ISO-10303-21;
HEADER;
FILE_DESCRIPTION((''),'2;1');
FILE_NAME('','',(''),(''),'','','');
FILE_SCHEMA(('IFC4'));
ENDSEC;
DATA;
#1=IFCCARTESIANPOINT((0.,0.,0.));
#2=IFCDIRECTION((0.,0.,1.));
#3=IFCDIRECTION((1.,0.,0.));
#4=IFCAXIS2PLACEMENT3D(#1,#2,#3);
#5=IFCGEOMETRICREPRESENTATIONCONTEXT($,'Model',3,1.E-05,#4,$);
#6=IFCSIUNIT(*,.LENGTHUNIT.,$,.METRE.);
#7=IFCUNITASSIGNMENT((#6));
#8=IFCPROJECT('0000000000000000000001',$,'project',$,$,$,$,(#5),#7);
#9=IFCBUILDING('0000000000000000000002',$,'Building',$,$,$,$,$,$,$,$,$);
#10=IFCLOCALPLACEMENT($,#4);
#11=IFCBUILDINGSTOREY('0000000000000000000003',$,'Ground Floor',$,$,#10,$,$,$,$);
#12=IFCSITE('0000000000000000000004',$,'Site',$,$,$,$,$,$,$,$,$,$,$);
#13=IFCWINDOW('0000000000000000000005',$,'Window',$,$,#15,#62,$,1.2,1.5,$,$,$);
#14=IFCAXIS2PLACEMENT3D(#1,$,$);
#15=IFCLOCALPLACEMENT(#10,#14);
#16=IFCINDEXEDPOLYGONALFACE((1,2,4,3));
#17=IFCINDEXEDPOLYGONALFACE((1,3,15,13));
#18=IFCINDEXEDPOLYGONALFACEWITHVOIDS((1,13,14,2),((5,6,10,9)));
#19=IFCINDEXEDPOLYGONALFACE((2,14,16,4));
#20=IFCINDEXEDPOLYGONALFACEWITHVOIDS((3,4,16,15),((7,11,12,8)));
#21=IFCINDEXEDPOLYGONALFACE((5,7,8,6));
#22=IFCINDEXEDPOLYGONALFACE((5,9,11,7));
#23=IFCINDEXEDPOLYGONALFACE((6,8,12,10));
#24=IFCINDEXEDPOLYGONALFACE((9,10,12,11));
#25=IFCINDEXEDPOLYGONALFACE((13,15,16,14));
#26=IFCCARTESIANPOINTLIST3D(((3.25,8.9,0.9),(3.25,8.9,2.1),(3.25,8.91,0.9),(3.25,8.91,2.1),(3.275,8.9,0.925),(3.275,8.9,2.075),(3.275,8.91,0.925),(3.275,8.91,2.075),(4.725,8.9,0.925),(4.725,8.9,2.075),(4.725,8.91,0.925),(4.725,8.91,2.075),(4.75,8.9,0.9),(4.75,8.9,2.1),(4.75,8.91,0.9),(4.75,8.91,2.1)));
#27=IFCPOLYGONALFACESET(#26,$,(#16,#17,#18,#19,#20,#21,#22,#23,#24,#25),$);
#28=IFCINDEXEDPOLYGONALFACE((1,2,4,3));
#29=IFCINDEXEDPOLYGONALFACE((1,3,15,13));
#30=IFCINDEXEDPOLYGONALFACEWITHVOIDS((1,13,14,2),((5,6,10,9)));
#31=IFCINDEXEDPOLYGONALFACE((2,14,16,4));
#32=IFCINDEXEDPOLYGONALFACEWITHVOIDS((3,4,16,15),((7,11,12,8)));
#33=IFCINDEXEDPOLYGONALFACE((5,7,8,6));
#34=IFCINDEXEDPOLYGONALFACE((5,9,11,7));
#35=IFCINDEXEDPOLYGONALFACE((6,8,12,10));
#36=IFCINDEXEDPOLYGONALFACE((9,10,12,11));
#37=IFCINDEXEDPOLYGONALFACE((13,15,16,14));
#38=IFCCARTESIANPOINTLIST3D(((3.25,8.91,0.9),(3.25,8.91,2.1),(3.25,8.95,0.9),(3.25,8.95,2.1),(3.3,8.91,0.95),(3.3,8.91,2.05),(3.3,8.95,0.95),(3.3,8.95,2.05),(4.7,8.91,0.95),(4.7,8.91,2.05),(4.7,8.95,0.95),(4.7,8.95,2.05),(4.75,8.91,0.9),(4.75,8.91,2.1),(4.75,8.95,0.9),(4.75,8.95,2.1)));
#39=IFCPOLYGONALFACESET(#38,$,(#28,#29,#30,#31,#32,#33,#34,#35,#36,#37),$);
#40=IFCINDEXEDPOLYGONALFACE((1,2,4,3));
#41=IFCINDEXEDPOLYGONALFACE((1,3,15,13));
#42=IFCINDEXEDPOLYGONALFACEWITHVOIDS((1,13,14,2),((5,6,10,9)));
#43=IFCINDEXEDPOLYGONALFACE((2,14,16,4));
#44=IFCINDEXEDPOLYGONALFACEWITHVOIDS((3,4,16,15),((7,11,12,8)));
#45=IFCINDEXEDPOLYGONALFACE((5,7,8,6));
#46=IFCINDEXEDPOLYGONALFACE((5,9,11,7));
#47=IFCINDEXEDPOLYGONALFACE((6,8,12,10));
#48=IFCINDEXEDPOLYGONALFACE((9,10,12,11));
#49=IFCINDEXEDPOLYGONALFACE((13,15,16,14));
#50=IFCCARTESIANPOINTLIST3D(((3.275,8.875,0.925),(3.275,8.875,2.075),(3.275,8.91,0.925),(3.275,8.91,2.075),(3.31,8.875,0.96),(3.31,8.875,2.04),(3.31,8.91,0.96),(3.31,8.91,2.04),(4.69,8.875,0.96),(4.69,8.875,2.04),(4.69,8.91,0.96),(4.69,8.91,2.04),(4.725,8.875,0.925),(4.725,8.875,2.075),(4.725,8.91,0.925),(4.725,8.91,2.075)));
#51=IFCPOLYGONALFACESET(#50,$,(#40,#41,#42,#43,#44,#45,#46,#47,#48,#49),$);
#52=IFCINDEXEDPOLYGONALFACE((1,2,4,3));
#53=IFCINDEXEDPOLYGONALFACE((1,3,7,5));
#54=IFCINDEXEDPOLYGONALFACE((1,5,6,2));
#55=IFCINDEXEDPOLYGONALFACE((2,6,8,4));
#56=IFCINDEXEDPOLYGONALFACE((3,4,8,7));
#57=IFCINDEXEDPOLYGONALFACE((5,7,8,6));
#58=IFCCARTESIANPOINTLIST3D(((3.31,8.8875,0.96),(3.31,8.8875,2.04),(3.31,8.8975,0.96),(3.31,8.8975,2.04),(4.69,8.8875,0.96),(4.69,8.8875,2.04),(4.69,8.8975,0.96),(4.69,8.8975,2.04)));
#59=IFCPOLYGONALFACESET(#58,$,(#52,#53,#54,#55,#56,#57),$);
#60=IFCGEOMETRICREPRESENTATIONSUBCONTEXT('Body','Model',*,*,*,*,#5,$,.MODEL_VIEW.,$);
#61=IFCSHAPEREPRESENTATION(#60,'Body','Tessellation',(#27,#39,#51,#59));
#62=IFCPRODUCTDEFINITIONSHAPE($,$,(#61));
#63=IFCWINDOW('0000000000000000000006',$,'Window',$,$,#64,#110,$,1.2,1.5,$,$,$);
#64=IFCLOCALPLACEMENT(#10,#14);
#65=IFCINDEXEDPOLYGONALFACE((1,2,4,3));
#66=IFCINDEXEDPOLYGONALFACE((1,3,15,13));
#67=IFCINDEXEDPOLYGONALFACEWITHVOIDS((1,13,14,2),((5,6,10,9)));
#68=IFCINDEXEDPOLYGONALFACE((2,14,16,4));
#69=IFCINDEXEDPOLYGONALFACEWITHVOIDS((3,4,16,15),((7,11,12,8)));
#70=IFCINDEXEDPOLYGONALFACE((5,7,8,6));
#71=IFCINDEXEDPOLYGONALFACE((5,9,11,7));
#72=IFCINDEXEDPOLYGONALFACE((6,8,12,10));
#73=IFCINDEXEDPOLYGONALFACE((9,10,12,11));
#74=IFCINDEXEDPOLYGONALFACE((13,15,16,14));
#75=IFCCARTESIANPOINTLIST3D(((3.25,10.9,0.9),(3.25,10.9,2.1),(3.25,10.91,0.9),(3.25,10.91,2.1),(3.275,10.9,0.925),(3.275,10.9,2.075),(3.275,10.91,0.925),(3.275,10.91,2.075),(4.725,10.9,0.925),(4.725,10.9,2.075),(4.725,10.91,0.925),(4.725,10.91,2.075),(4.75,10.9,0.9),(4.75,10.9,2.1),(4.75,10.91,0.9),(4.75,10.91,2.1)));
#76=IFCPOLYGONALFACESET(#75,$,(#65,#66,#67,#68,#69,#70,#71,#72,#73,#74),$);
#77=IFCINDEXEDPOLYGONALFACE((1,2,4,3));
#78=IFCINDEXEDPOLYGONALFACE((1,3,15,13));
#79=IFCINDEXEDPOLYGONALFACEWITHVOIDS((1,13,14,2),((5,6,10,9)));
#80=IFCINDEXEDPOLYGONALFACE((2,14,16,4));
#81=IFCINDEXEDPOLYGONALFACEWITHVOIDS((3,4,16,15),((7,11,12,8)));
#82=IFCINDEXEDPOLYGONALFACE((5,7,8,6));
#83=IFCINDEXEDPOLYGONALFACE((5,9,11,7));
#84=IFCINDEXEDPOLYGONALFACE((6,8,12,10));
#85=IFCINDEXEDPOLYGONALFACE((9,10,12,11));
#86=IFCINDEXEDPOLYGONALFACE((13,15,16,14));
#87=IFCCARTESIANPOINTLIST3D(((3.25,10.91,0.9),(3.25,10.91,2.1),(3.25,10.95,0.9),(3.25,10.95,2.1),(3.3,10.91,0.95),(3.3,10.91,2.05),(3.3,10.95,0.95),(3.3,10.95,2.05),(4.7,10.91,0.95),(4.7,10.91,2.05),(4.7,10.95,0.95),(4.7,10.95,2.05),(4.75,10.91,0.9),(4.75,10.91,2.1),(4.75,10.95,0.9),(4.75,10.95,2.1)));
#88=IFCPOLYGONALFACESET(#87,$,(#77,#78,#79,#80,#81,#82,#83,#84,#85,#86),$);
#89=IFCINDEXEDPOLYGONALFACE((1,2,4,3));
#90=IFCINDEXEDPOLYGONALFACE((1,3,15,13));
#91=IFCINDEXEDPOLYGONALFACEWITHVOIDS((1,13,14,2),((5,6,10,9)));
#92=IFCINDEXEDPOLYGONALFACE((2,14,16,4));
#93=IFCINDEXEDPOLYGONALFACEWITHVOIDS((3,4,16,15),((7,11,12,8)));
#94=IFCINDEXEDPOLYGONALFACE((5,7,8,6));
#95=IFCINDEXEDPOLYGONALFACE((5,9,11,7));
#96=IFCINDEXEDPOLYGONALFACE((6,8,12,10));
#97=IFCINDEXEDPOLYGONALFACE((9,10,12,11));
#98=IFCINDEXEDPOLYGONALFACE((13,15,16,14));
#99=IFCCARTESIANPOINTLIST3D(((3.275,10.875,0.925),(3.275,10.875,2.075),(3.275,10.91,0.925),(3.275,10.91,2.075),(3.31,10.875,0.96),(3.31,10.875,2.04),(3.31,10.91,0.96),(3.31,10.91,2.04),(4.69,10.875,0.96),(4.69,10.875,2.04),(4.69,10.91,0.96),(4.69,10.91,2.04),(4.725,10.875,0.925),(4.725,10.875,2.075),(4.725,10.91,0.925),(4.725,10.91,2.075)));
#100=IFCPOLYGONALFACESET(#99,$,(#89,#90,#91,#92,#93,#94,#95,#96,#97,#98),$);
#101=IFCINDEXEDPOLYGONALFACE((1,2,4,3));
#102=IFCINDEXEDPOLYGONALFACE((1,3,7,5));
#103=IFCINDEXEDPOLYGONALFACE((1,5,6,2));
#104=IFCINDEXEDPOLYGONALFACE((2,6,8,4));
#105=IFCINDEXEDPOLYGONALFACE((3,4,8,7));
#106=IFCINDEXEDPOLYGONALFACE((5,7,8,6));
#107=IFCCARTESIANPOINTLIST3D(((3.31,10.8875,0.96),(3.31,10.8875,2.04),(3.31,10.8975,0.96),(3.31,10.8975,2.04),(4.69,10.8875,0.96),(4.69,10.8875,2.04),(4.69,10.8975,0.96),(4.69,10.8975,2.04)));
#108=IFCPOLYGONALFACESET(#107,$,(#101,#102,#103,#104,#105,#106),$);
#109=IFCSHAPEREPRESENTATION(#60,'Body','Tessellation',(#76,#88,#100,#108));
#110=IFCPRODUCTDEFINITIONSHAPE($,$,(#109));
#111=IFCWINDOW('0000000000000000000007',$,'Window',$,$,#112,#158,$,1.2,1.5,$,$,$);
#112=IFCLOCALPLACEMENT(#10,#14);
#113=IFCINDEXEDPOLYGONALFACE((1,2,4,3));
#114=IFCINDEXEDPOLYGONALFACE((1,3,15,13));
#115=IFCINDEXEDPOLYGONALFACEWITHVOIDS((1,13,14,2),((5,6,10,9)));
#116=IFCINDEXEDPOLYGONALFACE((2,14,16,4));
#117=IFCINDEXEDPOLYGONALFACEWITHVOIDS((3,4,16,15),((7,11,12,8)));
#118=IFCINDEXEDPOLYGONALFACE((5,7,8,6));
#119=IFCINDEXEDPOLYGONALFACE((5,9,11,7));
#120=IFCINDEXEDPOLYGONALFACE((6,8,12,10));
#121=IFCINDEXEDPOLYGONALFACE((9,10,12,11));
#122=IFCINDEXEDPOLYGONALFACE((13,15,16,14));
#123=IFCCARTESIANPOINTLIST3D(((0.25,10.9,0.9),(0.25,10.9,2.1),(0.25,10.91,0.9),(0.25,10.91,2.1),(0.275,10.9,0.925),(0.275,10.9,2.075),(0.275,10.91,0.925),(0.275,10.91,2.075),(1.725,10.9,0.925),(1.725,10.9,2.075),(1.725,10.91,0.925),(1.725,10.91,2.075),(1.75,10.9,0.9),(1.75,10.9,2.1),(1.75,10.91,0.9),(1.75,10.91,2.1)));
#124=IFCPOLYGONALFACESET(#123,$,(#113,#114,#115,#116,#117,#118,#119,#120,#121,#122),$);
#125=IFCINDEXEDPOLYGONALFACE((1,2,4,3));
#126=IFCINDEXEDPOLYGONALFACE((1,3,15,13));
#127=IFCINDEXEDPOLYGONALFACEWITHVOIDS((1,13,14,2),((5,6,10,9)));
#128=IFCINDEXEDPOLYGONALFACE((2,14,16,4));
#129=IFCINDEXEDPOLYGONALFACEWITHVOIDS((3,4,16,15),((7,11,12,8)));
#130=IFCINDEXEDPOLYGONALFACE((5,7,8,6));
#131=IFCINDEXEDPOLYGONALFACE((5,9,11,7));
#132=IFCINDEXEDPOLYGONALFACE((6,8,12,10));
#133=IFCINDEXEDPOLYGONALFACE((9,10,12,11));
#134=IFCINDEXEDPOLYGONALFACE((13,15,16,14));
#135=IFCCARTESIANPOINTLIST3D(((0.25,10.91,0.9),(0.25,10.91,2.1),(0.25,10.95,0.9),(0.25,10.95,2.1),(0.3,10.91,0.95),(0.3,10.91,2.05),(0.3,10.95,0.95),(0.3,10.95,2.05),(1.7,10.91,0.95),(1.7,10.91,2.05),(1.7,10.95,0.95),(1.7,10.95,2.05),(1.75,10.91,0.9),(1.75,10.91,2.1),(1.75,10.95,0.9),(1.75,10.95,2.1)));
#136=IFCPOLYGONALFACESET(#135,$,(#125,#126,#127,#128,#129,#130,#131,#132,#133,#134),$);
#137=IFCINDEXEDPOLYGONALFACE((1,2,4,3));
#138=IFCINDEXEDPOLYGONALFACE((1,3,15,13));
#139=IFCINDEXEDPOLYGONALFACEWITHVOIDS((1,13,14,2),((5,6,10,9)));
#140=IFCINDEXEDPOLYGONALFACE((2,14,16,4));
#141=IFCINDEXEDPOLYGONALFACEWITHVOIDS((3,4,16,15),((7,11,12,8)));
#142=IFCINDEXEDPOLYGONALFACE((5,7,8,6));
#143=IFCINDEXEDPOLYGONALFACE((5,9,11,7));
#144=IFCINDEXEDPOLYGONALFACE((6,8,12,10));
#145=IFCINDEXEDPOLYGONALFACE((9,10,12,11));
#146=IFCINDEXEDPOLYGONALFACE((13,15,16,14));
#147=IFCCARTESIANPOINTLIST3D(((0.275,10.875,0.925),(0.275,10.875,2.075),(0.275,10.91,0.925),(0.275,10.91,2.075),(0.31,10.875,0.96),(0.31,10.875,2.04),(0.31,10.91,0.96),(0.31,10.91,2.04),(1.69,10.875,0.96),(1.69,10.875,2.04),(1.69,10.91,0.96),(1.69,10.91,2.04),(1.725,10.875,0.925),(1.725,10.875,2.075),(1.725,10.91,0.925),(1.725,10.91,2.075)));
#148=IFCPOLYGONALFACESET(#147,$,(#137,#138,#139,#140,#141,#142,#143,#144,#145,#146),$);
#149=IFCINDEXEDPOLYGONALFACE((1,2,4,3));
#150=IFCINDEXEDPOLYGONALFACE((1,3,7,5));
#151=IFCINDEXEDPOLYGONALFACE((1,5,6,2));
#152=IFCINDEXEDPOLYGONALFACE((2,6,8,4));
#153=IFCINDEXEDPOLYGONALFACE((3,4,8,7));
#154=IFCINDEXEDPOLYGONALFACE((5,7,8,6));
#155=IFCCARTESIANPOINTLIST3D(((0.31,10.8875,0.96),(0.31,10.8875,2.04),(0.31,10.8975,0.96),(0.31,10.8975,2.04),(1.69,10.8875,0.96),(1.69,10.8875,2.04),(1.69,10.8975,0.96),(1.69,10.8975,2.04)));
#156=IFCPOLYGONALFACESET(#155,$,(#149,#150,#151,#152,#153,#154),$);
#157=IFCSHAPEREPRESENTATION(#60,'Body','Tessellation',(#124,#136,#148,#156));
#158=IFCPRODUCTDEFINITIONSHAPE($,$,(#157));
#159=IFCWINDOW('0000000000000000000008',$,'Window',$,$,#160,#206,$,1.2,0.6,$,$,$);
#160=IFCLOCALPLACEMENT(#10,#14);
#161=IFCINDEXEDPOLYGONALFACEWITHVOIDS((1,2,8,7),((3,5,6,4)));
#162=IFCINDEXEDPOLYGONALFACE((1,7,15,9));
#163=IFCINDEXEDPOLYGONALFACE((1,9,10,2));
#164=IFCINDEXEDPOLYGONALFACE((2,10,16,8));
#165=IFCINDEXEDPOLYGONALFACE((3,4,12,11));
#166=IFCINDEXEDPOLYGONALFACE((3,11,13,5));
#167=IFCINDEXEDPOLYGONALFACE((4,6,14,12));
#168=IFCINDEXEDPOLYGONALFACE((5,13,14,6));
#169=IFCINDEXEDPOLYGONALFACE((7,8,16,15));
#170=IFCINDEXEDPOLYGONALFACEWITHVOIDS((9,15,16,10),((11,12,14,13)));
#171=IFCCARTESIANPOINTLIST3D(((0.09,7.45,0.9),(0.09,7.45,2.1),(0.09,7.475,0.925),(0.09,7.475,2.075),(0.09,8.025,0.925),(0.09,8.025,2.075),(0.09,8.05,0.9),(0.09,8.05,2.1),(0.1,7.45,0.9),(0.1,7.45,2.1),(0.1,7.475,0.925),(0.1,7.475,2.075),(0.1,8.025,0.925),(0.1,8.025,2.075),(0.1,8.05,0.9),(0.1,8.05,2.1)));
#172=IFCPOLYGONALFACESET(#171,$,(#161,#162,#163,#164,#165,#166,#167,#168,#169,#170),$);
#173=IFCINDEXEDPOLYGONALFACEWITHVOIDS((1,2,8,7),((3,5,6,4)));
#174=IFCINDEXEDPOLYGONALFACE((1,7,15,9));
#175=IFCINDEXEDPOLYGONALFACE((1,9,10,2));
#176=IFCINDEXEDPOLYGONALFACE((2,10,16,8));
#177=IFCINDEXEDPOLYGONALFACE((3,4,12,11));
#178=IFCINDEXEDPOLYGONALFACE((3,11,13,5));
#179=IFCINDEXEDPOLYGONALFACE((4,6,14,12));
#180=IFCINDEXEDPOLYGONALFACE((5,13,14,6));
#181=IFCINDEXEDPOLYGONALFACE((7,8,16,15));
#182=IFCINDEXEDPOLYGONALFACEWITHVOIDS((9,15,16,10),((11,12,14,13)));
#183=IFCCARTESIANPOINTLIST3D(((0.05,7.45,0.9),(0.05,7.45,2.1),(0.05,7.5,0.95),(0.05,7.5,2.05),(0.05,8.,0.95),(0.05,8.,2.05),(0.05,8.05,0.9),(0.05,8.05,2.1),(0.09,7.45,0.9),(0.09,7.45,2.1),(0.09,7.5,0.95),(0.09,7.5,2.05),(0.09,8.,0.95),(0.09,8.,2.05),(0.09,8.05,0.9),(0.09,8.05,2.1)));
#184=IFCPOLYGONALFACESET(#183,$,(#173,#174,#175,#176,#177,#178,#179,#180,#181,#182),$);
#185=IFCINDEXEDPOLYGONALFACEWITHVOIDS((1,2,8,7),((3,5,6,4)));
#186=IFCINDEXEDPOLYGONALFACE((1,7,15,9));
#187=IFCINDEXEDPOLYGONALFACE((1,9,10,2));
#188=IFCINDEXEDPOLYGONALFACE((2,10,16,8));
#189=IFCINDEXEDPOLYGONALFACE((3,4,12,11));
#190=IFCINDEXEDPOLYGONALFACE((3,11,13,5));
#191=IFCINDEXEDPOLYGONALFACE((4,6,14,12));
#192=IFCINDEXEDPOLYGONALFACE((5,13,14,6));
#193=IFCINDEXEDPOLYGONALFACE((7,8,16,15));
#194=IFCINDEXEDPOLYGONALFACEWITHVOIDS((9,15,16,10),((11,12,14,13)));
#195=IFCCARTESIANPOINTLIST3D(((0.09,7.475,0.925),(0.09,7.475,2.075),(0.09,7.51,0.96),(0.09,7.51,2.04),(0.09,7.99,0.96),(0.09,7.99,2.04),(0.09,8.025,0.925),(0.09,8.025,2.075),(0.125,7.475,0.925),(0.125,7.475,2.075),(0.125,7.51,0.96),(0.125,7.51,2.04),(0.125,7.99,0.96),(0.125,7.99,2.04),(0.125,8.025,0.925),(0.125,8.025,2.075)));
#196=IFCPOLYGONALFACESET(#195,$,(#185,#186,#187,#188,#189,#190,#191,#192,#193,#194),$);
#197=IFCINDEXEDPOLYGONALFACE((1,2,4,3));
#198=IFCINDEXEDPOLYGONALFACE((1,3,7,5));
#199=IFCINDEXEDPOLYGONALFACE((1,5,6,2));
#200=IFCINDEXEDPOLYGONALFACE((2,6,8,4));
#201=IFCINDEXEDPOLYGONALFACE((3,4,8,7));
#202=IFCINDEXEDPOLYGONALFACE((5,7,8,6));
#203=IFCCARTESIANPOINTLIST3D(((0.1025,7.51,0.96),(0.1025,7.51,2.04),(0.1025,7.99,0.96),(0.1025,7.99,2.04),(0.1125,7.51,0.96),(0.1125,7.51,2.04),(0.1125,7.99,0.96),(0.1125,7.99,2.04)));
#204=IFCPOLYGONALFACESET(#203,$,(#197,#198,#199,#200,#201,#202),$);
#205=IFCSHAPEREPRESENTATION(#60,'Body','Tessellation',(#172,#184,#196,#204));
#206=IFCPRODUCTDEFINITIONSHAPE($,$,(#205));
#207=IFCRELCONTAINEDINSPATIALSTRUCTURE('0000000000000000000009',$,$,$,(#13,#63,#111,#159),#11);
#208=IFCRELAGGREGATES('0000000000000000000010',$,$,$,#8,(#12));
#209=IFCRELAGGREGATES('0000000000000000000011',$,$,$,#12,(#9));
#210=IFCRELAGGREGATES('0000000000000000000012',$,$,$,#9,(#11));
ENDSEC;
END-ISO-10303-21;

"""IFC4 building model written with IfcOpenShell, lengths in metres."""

from ifc_helpers import new_model, si_unit, frame, origin_with_axes, place, context, subcontext, project, spatial, line, indexed_curve, outline, extrude, element, save


model = new_model("IFC4")

# Units and contexts
model_context = context("Model", 3, precision=1e-05, world=origin_with_axes())
body_context = subcontext(model_context, "Body", "Model", "MODEL_VIEW")
ifc_project = project(units=[si_unit("LENGTHUNIT", "METRE")], contexts=[model_context])

# Site, building, storey
site = spatial("IfcSite", under=ifc_project, Name="Site")
building = spatial("IfcBuilding", under=site, Name="Building")
storey_placement = place(None, origin_with_axes())
storey = spatial("IfcBuildingStorey", under=building, at=storey_placement, Name="Ground Floor")

# Windows
for number, where, z_axis, x_axis, name in (
    (1, (4.75, 9.0, 0.9), (0.0, 0.0, 1.0), (-1.0, 0.0, 0.0), "Window"),
    (2, (4.75, 11.0, 0.9), (0.0, 0.0, 1.0), (-1.0, 0.0, 0.0), "Window"),
    (3, (1.75, 11.0, 0.9), (0.0, 0.0, 1.0), (-1.0, 0.0, 0.0), "Window"),
):
    element("IfcWindow", number, at=place(storey_placement, frame(where, z_axis=z_axis, x_axis=x_axis)), inside=storey, Name=name, OverallHeight=1.2, OverallWidth=1.5, context=body_context, shape_type="SweptSolid", body=[
        extrude(outline(indexed_curve([(0.0, 0.0), (1.5, 0.0), (1.5, 1.2), (0.0, 1.2)], segments=[line(1, 2, 3, 4, 1)]), holes=[indexed_curve([(0.025, 0.025), (1.475, 0.025), (1.475, 1.175), (0.025, 1.175)], segments=[line(1, 2, 3, 4, 1)])]), frame((0.0, 0.09, 0.0), z_axis=(0.0, -1.0, 0.0), x_axis=(1.0, 0.0, 0.0)), (0.0, 0.0, -1.0), 0.01),
        extrude(outline(indexed_curve([(0.0, 0.0), (1.5, 0.0), (1.5, 1.2), (0.0, 1.2)], segments=[line(1, 2, 3, 4, 1)]), holes=[indexed_curve([(0.05, 0.05), (1.45, 0.05), (1.45, 1.15), (0.05, 1.15)], segments=[line(1, 2, 3, 4, 1)])]), frame((0.0, 0.05, 0.0), z_axis=(0.0, -1.0, 0.0), x_axis=(1.0, 0.0, 0.0)), (0.0, 0.0, -1.0), 0.04),
        extrude(outline(indexed_curve([(0.0, 0.0), (1.45, 0.0), (1.45, 1.15), (0.0, 1.15)], segments=[line(1, 2, 3, 4, 1)]), holes=[indexed_curve([(0.035, 0.035), (1.415, 0.035), (1.415, 1.115), (0.035, 1.115)], segments=[line(1, 2, 3, 4, 1)])]), frame((0.025, 0.09, 0.025), z_axis=(0.0, -1.0, 0.0), x_axis=(1.0, 0.0, 0.0)), (0.0, 0.0, -1.0), 0.035),
        extrude(outline(indexed_curve([(0.035, 0.035), (1.415, 0.035), (1.415, 1.115), (0.035, 1.115)], segments=[line(1, 2, 3, 4, 1)])), frame((0.025, 0.1025, 0.025), z_axis=(0.0, -1.0, 0.0), x_axis=(1.0, 0.0, 0.0)), (0.0, 0.0, -1.0), 0.01),
    ])
window_placement = place(storey_placement, frame((0.0, 8.05, 0.9), z_axis=(0.0, 0.0, 1.0), x_axis=(0.0, -1.0, 0.0)))
element("IfcWindow", 4, at=window_placement, inside=storey, Name="Window", OverallHeight=1.2, OverallWidth=0.6, context=body_context, shape_type="SweptSolid", body=[
    extrude(outline(indexed_curve([(0.0, 0.0), (0.6, 0.0), (0.6, 1.2), (0.0, 1.2)], segments=[line(1, 2, 3, 4, 1)]), holes=[indexed_curve([(0.025, 0.025), (0.575, 0.025), (0.575, 1.175), (0.025, 1.175)], segments=[line(1, 2, 3, 4, 1)])]), frame((0.0, 0.09, 0.0), z_axis=(0.0, -1.0, 0.0), x_axis=(1.0, 0.0, 0.0)), (0.0, 0.0, -1.0), 0.01),
    extrude(outline(indexed_curve([(0.0, 0.0), (0.6, 0.0), (0.6, 1.2), (0.0, 1.2)], segments=[line(1, 2, 3, 4, 1)]), holes=[indexed_curve([(0.05, 0.05), (0.55, 0.05), (0.55, 1.15), (0.05, 1.15)], segments=[line(1, 2, 3, 4, 1)])]), frame((0.0, 0.05, 0.0), z_axis=(0.0, -1.0, 0.0), x_axis=(1.0, 0.0, 0.0)), (0.0, 0.0, -1.0), 0.04),
    extrude(outline(indexed_curve([(0.0, 0.0), (0.55, 0.0), (0.55, 1.15), (0.0, 1.15)], segments=[line(1, 2, 3, 4, 1)]), holes=[indexed_curve([(0.035, 0.035), (0.515, 0.035), (0.515, 1.115), (0.035, 1.115)], segments=[line(1, 2, 3, 4, 1)])]), frame((0.025, 0.09, 0.025), z_axis=(0.0, -1.0, 0.0), x_axis=(1.0, 0.0, 0.0)), (0.0, 0.0, -1.0), 0.035),
    extrude(outline(indexed_curve([(0.035, 0.035), (0.515, 0.035), (0.515, 1.115), (0.035, 1.115)], segments=[line(1, 2, 3, 4, 1)])), frame((0.025, 0.1025, 0.025), z_axis=(0.0, -1.0, 0.0), x_axis=(1.0, 0.0, 0.0)), (0.0, 0.0, -1.0), 0.01),
])

save(model, "model.ifc")
